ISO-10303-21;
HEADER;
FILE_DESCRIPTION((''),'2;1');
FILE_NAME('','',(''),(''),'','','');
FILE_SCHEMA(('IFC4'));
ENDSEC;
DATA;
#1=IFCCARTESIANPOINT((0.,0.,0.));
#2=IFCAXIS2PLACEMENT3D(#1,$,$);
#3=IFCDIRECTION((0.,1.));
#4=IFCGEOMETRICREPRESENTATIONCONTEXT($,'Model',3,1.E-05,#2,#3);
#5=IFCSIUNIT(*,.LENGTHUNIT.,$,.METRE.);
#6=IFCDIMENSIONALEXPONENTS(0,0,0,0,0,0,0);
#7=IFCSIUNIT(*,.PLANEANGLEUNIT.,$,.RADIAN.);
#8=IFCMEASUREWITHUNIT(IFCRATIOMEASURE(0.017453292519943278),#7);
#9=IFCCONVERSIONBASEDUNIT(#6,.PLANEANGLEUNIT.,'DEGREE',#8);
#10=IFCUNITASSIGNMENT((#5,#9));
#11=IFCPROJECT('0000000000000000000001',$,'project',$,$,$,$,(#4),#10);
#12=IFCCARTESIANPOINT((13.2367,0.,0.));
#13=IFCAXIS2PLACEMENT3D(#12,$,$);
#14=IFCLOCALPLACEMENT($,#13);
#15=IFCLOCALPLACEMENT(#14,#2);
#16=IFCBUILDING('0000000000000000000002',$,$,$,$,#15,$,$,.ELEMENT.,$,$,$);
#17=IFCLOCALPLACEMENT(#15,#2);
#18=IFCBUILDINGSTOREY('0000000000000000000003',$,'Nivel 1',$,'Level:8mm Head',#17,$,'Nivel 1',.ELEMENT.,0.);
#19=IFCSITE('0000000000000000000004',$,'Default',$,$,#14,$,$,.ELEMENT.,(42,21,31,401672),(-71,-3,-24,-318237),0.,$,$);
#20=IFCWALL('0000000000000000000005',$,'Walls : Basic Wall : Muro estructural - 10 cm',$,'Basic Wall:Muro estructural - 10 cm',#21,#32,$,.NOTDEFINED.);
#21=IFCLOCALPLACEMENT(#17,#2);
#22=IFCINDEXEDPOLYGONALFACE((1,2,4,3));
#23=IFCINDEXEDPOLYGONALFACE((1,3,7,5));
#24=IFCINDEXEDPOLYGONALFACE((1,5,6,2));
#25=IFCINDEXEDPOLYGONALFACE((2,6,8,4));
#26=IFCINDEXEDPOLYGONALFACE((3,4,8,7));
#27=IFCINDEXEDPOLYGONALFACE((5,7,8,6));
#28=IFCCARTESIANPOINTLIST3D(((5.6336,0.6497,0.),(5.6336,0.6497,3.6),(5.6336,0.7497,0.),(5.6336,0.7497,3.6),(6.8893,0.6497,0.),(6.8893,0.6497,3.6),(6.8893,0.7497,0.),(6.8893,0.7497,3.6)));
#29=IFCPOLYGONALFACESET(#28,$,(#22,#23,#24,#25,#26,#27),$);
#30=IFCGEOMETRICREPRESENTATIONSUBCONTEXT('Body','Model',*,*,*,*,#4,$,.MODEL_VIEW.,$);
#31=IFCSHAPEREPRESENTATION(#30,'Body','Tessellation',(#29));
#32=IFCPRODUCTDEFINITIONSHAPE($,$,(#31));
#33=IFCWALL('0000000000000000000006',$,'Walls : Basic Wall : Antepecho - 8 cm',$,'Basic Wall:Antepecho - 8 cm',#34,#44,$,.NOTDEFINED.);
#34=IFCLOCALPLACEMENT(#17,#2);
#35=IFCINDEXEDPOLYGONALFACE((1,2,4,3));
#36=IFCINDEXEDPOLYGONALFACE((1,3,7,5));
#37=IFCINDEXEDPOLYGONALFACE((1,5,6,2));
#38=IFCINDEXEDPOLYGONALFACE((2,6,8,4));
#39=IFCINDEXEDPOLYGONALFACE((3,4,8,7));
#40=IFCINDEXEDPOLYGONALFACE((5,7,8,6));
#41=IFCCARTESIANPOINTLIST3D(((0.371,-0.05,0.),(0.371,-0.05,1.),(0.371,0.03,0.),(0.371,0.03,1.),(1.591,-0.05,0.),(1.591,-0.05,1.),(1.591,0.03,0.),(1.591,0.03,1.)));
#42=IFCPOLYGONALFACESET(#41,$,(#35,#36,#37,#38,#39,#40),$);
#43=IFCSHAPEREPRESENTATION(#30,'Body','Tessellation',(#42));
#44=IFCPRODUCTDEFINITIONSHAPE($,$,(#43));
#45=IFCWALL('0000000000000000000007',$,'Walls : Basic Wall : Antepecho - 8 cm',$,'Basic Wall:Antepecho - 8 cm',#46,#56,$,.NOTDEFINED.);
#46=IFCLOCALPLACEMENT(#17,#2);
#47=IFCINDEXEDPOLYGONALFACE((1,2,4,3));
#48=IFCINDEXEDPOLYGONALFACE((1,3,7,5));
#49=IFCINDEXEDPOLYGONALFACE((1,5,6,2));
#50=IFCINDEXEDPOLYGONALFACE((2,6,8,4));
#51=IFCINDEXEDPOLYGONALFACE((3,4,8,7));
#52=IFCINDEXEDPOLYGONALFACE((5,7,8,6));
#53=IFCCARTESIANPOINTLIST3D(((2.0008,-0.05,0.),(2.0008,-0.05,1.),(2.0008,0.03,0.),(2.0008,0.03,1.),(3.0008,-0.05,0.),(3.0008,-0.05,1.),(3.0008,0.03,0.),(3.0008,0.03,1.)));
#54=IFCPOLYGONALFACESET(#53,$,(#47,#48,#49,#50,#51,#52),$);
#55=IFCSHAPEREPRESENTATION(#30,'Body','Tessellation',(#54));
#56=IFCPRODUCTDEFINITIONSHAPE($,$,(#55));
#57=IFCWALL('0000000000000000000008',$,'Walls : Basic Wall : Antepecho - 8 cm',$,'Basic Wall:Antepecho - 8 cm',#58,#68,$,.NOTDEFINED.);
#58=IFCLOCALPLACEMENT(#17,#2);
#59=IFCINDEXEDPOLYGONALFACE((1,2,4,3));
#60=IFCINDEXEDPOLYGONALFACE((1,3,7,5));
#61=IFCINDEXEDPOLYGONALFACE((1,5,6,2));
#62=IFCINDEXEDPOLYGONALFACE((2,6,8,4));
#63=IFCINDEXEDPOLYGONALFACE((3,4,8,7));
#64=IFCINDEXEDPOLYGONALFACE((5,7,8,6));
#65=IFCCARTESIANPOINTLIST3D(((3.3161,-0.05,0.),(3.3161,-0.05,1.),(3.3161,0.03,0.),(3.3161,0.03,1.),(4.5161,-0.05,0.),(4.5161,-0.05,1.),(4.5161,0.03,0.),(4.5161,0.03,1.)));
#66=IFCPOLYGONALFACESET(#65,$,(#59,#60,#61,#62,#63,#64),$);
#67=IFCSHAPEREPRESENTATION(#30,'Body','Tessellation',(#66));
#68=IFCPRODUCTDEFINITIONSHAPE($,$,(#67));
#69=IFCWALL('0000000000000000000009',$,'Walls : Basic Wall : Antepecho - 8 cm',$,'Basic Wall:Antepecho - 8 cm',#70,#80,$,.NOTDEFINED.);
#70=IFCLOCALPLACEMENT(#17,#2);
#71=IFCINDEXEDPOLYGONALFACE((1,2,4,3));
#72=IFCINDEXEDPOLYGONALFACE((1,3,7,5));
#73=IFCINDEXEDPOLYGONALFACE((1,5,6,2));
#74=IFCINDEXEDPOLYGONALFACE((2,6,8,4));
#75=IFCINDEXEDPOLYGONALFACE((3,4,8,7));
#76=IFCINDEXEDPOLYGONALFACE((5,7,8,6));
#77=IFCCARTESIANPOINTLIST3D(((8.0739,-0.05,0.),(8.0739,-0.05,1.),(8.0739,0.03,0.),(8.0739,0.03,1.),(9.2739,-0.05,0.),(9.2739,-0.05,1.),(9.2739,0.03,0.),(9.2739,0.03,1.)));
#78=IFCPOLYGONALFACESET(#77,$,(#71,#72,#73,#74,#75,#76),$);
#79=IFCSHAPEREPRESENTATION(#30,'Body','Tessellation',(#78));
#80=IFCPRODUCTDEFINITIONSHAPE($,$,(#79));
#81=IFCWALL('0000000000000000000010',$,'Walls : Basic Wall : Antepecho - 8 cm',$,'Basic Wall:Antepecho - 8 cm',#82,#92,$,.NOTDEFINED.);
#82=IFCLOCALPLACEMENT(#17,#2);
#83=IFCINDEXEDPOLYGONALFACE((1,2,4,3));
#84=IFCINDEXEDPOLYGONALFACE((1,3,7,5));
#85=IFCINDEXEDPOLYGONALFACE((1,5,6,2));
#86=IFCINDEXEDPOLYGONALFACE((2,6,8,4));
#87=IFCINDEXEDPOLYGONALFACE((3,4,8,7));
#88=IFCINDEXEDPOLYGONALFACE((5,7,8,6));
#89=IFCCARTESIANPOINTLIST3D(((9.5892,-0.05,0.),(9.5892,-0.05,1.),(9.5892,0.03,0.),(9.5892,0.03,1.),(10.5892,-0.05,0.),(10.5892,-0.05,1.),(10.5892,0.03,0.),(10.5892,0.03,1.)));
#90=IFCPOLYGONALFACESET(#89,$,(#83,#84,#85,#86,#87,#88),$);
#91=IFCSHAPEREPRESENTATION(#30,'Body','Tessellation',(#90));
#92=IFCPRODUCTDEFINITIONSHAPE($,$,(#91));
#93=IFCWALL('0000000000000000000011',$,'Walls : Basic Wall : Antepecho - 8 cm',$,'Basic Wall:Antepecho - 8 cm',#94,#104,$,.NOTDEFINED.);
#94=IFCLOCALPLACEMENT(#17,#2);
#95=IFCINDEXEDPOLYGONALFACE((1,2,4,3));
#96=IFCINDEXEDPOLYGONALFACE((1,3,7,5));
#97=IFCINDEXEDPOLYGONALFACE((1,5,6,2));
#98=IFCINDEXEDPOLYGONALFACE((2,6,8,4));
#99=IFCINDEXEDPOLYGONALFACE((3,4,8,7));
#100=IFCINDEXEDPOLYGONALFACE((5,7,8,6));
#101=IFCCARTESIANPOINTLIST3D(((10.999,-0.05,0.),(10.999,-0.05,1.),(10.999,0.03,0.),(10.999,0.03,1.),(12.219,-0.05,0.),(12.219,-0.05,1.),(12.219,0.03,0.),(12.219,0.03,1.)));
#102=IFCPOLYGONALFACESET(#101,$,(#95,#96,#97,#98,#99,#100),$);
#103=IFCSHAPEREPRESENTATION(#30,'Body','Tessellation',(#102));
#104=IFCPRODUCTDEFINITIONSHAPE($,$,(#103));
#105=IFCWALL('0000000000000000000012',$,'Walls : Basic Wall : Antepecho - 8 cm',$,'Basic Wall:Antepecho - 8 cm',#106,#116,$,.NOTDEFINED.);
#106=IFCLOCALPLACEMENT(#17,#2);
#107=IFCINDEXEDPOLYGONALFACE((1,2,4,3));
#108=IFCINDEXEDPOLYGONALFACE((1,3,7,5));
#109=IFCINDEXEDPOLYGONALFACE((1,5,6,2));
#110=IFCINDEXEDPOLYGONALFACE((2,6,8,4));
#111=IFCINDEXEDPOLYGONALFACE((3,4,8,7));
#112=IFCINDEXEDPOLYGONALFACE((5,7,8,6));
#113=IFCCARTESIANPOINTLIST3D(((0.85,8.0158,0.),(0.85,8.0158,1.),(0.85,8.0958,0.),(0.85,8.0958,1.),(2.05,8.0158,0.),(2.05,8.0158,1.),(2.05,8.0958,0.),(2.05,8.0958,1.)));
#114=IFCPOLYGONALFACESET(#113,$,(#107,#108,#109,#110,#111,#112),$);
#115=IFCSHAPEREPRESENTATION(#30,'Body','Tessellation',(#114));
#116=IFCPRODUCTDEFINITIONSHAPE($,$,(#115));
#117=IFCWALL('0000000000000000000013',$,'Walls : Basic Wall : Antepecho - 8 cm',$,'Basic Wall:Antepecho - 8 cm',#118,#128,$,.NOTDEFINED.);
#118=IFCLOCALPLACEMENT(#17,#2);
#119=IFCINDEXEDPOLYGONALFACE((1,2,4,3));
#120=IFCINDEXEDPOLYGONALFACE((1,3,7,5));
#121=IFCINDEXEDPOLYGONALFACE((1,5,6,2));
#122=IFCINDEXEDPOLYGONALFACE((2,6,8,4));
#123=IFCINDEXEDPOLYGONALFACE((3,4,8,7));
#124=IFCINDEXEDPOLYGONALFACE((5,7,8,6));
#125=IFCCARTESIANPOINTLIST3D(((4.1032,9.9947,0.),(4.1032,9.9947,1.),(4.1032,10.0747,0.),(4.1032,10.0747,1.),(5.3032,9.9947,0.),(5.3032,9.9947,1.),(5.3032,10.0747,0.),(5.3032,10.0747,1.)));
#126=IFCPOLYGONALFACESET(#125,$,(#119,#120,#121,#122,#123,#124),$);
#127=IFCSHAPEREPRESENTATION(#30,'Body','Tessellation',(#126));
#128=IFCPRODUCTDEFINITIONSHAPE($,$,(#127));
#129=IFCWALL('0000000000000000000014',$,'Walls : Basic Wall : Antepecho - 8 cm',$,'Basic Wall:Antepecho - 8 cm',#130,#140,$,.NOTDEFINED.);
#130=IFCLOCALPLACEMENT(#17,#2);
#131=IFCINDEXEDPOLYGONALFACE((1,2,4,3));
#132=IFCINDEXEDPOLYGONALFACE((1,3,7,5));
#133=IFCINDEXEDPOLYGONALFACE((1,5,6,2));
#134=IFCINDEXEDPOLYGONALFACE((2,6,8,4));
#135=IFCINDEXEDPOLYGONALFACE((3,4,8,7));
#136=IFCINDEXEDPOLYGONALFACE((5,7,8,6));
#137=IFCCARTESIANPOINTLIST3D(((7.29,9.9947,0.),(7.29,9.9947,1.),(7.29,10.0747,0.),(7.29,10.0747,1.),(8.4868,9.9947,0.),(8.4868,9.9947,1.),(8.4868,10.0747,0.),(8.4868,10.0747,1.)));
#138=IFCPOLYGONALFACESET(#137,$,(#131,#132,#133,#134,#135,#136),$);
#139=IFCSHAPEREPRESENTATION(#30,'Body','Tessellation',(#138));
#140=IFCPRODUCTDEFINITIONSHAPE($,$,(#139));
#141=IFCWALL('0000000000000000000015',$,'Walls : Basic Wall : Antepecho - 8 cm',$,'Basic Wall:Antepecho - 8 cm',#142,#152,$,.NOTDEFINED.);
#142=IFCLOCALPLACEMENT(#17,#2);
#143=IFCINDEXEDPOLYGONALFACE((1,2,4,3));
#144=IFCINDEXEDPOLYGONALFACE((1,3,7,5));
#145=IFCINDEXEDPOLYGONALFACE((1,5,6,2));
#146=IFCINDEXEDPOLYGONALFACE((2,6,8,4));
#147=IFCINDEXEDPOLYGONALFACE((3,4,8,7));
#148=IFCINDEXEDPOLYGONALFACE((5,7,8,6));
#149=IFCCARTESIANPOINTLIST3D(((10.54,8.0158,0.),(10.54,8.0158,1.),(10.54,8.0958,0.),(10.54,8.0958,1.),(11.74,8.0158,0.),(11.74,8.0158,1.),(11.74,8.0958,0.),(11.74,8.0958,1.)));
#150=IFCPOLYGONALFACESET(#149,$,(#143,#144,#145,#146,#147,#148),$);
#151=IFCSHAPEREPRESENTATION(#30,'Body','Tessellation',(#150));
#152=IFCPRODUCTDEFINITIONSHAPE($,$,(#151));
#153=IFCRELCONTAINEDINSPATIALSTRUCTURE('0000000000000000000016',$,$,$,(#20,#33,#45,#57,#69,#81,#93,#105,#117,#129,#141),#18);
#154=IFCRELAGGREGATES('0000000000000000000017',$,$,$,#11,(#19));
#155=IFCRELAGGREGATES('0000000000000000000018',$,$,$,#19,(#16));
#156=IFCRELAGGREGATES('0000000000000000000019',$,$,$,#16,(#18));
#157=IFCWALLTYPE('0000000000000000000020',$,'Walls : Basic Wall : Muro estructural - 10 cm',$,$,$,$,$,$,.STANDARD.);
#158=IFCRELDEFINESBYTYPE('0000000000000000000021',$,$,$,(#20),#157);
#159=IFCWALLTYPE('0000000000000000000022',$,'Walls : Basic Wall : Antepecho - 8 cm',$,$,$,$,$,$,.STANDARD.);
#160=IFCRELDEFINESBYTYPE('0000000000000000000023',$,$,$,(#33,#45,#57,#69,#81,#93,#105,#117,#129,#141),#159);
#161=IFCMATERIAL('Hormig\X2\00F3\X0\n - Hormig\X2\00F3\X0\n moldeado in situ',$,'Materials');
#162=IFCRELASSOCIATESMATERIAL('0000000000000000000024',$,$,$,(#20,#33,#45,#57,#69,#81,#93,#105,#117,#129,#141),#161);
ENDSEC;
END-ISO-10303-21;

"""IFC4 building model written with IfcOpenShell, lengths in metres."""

from ifc_helpers import new_model, entity, si_unit, converted_unit, direction, frame, origin, place, context, subcontext, project, spatial, indexed_curve, outline, extrude, material, type_object, element, save


model = new_model("IFC4")

# Units and contexts
model_context = context("Model", 3, precision=1e-05, world=origin(), true_north=direction((0.0, 1.0)))
body_context = subcontext(model_context, "Body", "Model", "MODEL_VIEW")
ifc_project = project(units=[si_unit("LENGTHUNIT", "METRE"), converted_unit("PLANEANGLEUNIT", "DEGREE", entity("IfcRatioMeasure", 0.017453292519943278), si_unit("PLANEANGLEUNIT", "RADIAN"), dimensions=[0, 0, 0, 0, 0, 0, 0])], contexts=[model_context])

# Site, building, storey
site_placement = place(None, frame((13.2367, 0.0, 0.0)))
site = spatial("IfcSite", under=ifc_project, at=site_placement, Name="Default", CompositionType="ELEMENT", RefLatitude=(42, 21, 31, 401672), RefLongitude=(-71, -3, -24, -318237), RefElevation=0.0)
building_placement = place(site_placement, origin())
building = spatial("IfcBuilding", under=site, at=building_placement, CompositionType="ELEMENT")
storey_placement = place(building_placement, origin())
storey = spatial("IfcBuildingStorey", under=building, at=storey_placement, Name="Nivel 1", ObjectType="Level:8mm Head", LongName="Nivel 1", CompositionType="ELEMENT", Elevation=0.0)

# Walls
ifc_material_1 = material(Name="Hormigón - Hormigón moldeado in situ", Category="Materials")
wall_type_1 = type_object("IfcWallType", Name="Walls : Basic Wall : Muro estructural - 10 cm", PredefinedType="STANDARD")
wall_1_placement = place(storey_placement, frame((5.6336, 0.6997, 0.0)))
element("IfcWall", 1, at=wall_1_placement, inside=storey, type_object=wall_type_1, material=ifc_material_1, Name="Walls : Basic Wall : Muro estructural - 10 cm", ObjectType="Basic Wall:Muro estructural - 10 cm", PredefinedType="NOTDEFINED", context=body_context, shape_type="SweptSolid", body=[
    extrude(outline(indexed_curve([(1.2557, 0.05), (0.0, 0.05), (0.0, -0.05), (1.2557, -0.05), (1.2557, 0.05)], self_intersect=False)), origin(), (0.0, 0.0, 1.0), 3.6),
])
wall_type_2 = type_object("IfcWallType", Name="Walls : Basic Wall : Antepecho - 8 cm", PredefinedType="STANDARD")
wall_2_placement = place(storey_placement, frame((0.371, -0.01, 0.0)))
element("IfcWall", 2, at=wall_2_placement, inside=storey, type_object=wall_type_2, material=ifc_material_1, Name="Walls : Basic Wall : Antepecho - 8 cm", ObjectType="Basic Wall:Antepecho - 8 cm", PredefinedType="NOTDEFINED", context=body_context, shape_type="SweptSolid", body=[
    extrude(outline(indexed_curve([(1.22, 0.04), (0.0, 0.04), (0.0, -0.04), (1.22, -0.04), (1.22, 0.04)], self_intersect=False)), origin(), (0.0, 0.0, 1.0), 1.0),
])
wall_3_placement = place(storey_placement, frame((2.0008, -0.01, 0.0)))
element("IfcWall", 3, at=wall_3_placement, inside=storey, type_object=wall_type_2, material=ifc_material_1, Name="Walls : Basic Wall : Antepecho - 8 cm", ObjectType="Basic Wall:Antepecho - 8 cm", PredefinedType="NOTDEFINED", context=body_context, shape_type="SweptSolid", body=[
    extrude(outline(indexed_curve([(1.0, 0.04), (0.0, 0.04), (0.0, -0.04), (1.0, -0.04), (1.0, 0.04)], self_intersect=False)), origin(), (0.0, 0.0, 1.0), 1.0),
])
wall_4_placement = place(storey_placement, frame((3.3161, -0.01, 0.0)))
element("IfcWall", 4, at=wall_4_placement, inside=storey, type_object=wall_type_2, material=ifc_material_1, Name="Walls : Basic Wall : Antepecho - 8 cm", ObjectType="Basic Wall:Antepecho - 8 cm", PredefinedType="NOTDEFINED", context=body_context, shape_type="SweptSolid", body=[
    extrude(outline(indexed_curve([(1.2, 0.04), (0.0, 0.04), (0.0, -0.04), (1.2, -0.04), (1.2, 0.04)], self_intersect=False)), origin(), (0.0, 0.0, 1.0), 1.0),
])
wall_5_placement = place(storey_placement, frame((8.0739, -0.01, 0.0)))
element("IfcWall", 5, at=wall_5_placement, inside=storey, type_object=wall_type_2, material=ifc_material_1, Name="Walls : Basic Wall : Antepecho - 8 cm", ObjectType="Basic Wall:Antepecho - 8 cm", PredefinedType="NOTDEFINED", context=body_context, shape_type="SweptSolid", body=[
    extrude(outline(indexed_curve([(1.2, 0.04), (0.0, 0.04), (0.0, -0.04), (1.2, -0.04), (1.2, 0.04)], self_intersect=False)), origin(), (0.0, 0.0, 1.0), 1.0),
])
wall_6_placement = place(storey_placement, frame((9.5892, -0.01, 0.0)))
element("IfcWall", 6, at=wall_6_placement, inside=storey, type_object=wall_type_2, material=ifc_material_1, Name="Walls : Basic Wall : Antepecho - 8 cm", ObjectType="Basic Wall:Antepecho - 8 cm", PredefinedType="NOTDEFINED", context=body_context, shape_type="SweptSolid", body=[
    extrude(outline(indexed_curve([(1.0, 0.04), (0.0, 0.04), (0.0, -0.04), (1.0, -0.04), (1.0, 0.04)], self_intersect=False)), origin(), (0.0, 0.0, 1.0), 1.0),
])
wall_7_placement = place(storey_placement, frame((10.999, -0.01, 0.0)))
element("IfcWall", 7, at=wall_7_placement, inside=storey, type_object=wall_type_2, material=ifc_material_1, Name="Walls : Basic Wall : Antepecho - 8 cm", ObjectType="Basic Wall:Antepecho - 8 cm", PredefinedType="NOTDEFINED", context=body_context, shape_type="SweptSolid", body=[
    extrude(outline(indexed_curve([(1.22, 0.04), (0.0, 0.04), (0.0, -0.04), (1.22, -0.04), (1.22, 0.04)], self_intersect=False)), origin(), (0.0, 0.0, 1.0), 1.0),
])
wall_8_placement = place(storey_placement, frame((2.05, 8.0558, 0.0), z_axis=(0.0, 0.0, 1.0), x_axis=(-1.0, 0.0, 0.0)))
element("IfcWall", 8, at=wall_8_placement, inside=storey, type_object=wall_type_2, material=ifc_material_1, Name="Walls : Basic Wall : Antepecho - 8 cm", ObjectType="Basic Wall:Antepecho - 8 cm", PredefinedType="NOTDEFINED", context=body_context, shape_type="SweptSolid", body=[
    extrude(outline(indexed_curve([(1.2, 0.04), (0.0, 0.04), (0.0, -0.04), (1.2, -0.04), (1.2, 0.04)], self_intersect=False)), origin(), (0.0, 0.0, 1.0), 1.0),
])
wall_9_placement = place(storey_placement, frame((5.3032, 10.0347, 0.0), z_axis=(0.0, 0.0, 1.0), x_axis=(-1.0, 0.0, 0.0)))
element("IfcWall", 9, at=wall_9_placement, inside=storey, type_object=wall_type_2, material=ifc_material_1, Name="Walls : Basic Wall : Antepecho - 8 cm", ObjectType="Basic Wall:Antepecho - 8 cm", PredefinedType="NOTDEFINED", context=body_context, shape_type="SweptSolid", body=[
    extrude(outline(indexed_curve([(1.2, 0.04), (0.0, 0.04), (0.0, -0.04), (1.2, -0.04), (1.2, 0.04)], self_intersect=False)), origin(), (0.0, 0.0, 1.0), 1.0),
])
wall_10_placement = place(storey_placement, frame((8.4868, 10.0347, 0.0), z_axis=(0.0, 0.0, 1.0), x_axis=(-1.0, 0.0, 0.0)))
element("IfcWall", 10, at=wall_10_placement, inside=storey, type_object=wall_type_2, material=ifc_material_1, Name="Walls : Basic Wall : Antepecho - 8 cm", ObjectType="Basic Wall:Antepecho - 8 cm", PredefinedType="NOTDEFINED", context=body_context, shape_type="SweptSolid", body=[
    extrude(outline(indexed_curve([(1.1968, 0.04), (0.0, 0.04), (0.0, -0.04), (1.1968, -0.04), (1.1968, 0.04)], self_intersect=False)), origin(), (0.0, 0.0, 1.0), 1.0),
])
wall_11_placement = place(storey_placement, frame((11.74, 8.0558, 0.0), z_axis=(0.0, 0.0, 1.0), x_axis=(-1.0, 0.0, 0.0)))
element("IfcWall", 11, at=wall_11_placement, inside=storey, type_object=wall_type_2, material=ifc_material_1, Name="Walls : Basic Wall : Antepecho - 8 cm", ObjectType="Basic Wall:Antepecho - 8 cm", PredefinedType="NOTDEFINED", context=body_context, shape_type="SweptSolid", body=[
    extrude(outline(indexed_curve([(1.2, 0.04), (0.0, 0.04), (0.0, -0.04), (1.2, -0.04), (1.2, 0.04)], self_intersect=False)), origin(), (0.0, 0.0, 1.0), 1.0),
])

save(model, "model.ifc")
